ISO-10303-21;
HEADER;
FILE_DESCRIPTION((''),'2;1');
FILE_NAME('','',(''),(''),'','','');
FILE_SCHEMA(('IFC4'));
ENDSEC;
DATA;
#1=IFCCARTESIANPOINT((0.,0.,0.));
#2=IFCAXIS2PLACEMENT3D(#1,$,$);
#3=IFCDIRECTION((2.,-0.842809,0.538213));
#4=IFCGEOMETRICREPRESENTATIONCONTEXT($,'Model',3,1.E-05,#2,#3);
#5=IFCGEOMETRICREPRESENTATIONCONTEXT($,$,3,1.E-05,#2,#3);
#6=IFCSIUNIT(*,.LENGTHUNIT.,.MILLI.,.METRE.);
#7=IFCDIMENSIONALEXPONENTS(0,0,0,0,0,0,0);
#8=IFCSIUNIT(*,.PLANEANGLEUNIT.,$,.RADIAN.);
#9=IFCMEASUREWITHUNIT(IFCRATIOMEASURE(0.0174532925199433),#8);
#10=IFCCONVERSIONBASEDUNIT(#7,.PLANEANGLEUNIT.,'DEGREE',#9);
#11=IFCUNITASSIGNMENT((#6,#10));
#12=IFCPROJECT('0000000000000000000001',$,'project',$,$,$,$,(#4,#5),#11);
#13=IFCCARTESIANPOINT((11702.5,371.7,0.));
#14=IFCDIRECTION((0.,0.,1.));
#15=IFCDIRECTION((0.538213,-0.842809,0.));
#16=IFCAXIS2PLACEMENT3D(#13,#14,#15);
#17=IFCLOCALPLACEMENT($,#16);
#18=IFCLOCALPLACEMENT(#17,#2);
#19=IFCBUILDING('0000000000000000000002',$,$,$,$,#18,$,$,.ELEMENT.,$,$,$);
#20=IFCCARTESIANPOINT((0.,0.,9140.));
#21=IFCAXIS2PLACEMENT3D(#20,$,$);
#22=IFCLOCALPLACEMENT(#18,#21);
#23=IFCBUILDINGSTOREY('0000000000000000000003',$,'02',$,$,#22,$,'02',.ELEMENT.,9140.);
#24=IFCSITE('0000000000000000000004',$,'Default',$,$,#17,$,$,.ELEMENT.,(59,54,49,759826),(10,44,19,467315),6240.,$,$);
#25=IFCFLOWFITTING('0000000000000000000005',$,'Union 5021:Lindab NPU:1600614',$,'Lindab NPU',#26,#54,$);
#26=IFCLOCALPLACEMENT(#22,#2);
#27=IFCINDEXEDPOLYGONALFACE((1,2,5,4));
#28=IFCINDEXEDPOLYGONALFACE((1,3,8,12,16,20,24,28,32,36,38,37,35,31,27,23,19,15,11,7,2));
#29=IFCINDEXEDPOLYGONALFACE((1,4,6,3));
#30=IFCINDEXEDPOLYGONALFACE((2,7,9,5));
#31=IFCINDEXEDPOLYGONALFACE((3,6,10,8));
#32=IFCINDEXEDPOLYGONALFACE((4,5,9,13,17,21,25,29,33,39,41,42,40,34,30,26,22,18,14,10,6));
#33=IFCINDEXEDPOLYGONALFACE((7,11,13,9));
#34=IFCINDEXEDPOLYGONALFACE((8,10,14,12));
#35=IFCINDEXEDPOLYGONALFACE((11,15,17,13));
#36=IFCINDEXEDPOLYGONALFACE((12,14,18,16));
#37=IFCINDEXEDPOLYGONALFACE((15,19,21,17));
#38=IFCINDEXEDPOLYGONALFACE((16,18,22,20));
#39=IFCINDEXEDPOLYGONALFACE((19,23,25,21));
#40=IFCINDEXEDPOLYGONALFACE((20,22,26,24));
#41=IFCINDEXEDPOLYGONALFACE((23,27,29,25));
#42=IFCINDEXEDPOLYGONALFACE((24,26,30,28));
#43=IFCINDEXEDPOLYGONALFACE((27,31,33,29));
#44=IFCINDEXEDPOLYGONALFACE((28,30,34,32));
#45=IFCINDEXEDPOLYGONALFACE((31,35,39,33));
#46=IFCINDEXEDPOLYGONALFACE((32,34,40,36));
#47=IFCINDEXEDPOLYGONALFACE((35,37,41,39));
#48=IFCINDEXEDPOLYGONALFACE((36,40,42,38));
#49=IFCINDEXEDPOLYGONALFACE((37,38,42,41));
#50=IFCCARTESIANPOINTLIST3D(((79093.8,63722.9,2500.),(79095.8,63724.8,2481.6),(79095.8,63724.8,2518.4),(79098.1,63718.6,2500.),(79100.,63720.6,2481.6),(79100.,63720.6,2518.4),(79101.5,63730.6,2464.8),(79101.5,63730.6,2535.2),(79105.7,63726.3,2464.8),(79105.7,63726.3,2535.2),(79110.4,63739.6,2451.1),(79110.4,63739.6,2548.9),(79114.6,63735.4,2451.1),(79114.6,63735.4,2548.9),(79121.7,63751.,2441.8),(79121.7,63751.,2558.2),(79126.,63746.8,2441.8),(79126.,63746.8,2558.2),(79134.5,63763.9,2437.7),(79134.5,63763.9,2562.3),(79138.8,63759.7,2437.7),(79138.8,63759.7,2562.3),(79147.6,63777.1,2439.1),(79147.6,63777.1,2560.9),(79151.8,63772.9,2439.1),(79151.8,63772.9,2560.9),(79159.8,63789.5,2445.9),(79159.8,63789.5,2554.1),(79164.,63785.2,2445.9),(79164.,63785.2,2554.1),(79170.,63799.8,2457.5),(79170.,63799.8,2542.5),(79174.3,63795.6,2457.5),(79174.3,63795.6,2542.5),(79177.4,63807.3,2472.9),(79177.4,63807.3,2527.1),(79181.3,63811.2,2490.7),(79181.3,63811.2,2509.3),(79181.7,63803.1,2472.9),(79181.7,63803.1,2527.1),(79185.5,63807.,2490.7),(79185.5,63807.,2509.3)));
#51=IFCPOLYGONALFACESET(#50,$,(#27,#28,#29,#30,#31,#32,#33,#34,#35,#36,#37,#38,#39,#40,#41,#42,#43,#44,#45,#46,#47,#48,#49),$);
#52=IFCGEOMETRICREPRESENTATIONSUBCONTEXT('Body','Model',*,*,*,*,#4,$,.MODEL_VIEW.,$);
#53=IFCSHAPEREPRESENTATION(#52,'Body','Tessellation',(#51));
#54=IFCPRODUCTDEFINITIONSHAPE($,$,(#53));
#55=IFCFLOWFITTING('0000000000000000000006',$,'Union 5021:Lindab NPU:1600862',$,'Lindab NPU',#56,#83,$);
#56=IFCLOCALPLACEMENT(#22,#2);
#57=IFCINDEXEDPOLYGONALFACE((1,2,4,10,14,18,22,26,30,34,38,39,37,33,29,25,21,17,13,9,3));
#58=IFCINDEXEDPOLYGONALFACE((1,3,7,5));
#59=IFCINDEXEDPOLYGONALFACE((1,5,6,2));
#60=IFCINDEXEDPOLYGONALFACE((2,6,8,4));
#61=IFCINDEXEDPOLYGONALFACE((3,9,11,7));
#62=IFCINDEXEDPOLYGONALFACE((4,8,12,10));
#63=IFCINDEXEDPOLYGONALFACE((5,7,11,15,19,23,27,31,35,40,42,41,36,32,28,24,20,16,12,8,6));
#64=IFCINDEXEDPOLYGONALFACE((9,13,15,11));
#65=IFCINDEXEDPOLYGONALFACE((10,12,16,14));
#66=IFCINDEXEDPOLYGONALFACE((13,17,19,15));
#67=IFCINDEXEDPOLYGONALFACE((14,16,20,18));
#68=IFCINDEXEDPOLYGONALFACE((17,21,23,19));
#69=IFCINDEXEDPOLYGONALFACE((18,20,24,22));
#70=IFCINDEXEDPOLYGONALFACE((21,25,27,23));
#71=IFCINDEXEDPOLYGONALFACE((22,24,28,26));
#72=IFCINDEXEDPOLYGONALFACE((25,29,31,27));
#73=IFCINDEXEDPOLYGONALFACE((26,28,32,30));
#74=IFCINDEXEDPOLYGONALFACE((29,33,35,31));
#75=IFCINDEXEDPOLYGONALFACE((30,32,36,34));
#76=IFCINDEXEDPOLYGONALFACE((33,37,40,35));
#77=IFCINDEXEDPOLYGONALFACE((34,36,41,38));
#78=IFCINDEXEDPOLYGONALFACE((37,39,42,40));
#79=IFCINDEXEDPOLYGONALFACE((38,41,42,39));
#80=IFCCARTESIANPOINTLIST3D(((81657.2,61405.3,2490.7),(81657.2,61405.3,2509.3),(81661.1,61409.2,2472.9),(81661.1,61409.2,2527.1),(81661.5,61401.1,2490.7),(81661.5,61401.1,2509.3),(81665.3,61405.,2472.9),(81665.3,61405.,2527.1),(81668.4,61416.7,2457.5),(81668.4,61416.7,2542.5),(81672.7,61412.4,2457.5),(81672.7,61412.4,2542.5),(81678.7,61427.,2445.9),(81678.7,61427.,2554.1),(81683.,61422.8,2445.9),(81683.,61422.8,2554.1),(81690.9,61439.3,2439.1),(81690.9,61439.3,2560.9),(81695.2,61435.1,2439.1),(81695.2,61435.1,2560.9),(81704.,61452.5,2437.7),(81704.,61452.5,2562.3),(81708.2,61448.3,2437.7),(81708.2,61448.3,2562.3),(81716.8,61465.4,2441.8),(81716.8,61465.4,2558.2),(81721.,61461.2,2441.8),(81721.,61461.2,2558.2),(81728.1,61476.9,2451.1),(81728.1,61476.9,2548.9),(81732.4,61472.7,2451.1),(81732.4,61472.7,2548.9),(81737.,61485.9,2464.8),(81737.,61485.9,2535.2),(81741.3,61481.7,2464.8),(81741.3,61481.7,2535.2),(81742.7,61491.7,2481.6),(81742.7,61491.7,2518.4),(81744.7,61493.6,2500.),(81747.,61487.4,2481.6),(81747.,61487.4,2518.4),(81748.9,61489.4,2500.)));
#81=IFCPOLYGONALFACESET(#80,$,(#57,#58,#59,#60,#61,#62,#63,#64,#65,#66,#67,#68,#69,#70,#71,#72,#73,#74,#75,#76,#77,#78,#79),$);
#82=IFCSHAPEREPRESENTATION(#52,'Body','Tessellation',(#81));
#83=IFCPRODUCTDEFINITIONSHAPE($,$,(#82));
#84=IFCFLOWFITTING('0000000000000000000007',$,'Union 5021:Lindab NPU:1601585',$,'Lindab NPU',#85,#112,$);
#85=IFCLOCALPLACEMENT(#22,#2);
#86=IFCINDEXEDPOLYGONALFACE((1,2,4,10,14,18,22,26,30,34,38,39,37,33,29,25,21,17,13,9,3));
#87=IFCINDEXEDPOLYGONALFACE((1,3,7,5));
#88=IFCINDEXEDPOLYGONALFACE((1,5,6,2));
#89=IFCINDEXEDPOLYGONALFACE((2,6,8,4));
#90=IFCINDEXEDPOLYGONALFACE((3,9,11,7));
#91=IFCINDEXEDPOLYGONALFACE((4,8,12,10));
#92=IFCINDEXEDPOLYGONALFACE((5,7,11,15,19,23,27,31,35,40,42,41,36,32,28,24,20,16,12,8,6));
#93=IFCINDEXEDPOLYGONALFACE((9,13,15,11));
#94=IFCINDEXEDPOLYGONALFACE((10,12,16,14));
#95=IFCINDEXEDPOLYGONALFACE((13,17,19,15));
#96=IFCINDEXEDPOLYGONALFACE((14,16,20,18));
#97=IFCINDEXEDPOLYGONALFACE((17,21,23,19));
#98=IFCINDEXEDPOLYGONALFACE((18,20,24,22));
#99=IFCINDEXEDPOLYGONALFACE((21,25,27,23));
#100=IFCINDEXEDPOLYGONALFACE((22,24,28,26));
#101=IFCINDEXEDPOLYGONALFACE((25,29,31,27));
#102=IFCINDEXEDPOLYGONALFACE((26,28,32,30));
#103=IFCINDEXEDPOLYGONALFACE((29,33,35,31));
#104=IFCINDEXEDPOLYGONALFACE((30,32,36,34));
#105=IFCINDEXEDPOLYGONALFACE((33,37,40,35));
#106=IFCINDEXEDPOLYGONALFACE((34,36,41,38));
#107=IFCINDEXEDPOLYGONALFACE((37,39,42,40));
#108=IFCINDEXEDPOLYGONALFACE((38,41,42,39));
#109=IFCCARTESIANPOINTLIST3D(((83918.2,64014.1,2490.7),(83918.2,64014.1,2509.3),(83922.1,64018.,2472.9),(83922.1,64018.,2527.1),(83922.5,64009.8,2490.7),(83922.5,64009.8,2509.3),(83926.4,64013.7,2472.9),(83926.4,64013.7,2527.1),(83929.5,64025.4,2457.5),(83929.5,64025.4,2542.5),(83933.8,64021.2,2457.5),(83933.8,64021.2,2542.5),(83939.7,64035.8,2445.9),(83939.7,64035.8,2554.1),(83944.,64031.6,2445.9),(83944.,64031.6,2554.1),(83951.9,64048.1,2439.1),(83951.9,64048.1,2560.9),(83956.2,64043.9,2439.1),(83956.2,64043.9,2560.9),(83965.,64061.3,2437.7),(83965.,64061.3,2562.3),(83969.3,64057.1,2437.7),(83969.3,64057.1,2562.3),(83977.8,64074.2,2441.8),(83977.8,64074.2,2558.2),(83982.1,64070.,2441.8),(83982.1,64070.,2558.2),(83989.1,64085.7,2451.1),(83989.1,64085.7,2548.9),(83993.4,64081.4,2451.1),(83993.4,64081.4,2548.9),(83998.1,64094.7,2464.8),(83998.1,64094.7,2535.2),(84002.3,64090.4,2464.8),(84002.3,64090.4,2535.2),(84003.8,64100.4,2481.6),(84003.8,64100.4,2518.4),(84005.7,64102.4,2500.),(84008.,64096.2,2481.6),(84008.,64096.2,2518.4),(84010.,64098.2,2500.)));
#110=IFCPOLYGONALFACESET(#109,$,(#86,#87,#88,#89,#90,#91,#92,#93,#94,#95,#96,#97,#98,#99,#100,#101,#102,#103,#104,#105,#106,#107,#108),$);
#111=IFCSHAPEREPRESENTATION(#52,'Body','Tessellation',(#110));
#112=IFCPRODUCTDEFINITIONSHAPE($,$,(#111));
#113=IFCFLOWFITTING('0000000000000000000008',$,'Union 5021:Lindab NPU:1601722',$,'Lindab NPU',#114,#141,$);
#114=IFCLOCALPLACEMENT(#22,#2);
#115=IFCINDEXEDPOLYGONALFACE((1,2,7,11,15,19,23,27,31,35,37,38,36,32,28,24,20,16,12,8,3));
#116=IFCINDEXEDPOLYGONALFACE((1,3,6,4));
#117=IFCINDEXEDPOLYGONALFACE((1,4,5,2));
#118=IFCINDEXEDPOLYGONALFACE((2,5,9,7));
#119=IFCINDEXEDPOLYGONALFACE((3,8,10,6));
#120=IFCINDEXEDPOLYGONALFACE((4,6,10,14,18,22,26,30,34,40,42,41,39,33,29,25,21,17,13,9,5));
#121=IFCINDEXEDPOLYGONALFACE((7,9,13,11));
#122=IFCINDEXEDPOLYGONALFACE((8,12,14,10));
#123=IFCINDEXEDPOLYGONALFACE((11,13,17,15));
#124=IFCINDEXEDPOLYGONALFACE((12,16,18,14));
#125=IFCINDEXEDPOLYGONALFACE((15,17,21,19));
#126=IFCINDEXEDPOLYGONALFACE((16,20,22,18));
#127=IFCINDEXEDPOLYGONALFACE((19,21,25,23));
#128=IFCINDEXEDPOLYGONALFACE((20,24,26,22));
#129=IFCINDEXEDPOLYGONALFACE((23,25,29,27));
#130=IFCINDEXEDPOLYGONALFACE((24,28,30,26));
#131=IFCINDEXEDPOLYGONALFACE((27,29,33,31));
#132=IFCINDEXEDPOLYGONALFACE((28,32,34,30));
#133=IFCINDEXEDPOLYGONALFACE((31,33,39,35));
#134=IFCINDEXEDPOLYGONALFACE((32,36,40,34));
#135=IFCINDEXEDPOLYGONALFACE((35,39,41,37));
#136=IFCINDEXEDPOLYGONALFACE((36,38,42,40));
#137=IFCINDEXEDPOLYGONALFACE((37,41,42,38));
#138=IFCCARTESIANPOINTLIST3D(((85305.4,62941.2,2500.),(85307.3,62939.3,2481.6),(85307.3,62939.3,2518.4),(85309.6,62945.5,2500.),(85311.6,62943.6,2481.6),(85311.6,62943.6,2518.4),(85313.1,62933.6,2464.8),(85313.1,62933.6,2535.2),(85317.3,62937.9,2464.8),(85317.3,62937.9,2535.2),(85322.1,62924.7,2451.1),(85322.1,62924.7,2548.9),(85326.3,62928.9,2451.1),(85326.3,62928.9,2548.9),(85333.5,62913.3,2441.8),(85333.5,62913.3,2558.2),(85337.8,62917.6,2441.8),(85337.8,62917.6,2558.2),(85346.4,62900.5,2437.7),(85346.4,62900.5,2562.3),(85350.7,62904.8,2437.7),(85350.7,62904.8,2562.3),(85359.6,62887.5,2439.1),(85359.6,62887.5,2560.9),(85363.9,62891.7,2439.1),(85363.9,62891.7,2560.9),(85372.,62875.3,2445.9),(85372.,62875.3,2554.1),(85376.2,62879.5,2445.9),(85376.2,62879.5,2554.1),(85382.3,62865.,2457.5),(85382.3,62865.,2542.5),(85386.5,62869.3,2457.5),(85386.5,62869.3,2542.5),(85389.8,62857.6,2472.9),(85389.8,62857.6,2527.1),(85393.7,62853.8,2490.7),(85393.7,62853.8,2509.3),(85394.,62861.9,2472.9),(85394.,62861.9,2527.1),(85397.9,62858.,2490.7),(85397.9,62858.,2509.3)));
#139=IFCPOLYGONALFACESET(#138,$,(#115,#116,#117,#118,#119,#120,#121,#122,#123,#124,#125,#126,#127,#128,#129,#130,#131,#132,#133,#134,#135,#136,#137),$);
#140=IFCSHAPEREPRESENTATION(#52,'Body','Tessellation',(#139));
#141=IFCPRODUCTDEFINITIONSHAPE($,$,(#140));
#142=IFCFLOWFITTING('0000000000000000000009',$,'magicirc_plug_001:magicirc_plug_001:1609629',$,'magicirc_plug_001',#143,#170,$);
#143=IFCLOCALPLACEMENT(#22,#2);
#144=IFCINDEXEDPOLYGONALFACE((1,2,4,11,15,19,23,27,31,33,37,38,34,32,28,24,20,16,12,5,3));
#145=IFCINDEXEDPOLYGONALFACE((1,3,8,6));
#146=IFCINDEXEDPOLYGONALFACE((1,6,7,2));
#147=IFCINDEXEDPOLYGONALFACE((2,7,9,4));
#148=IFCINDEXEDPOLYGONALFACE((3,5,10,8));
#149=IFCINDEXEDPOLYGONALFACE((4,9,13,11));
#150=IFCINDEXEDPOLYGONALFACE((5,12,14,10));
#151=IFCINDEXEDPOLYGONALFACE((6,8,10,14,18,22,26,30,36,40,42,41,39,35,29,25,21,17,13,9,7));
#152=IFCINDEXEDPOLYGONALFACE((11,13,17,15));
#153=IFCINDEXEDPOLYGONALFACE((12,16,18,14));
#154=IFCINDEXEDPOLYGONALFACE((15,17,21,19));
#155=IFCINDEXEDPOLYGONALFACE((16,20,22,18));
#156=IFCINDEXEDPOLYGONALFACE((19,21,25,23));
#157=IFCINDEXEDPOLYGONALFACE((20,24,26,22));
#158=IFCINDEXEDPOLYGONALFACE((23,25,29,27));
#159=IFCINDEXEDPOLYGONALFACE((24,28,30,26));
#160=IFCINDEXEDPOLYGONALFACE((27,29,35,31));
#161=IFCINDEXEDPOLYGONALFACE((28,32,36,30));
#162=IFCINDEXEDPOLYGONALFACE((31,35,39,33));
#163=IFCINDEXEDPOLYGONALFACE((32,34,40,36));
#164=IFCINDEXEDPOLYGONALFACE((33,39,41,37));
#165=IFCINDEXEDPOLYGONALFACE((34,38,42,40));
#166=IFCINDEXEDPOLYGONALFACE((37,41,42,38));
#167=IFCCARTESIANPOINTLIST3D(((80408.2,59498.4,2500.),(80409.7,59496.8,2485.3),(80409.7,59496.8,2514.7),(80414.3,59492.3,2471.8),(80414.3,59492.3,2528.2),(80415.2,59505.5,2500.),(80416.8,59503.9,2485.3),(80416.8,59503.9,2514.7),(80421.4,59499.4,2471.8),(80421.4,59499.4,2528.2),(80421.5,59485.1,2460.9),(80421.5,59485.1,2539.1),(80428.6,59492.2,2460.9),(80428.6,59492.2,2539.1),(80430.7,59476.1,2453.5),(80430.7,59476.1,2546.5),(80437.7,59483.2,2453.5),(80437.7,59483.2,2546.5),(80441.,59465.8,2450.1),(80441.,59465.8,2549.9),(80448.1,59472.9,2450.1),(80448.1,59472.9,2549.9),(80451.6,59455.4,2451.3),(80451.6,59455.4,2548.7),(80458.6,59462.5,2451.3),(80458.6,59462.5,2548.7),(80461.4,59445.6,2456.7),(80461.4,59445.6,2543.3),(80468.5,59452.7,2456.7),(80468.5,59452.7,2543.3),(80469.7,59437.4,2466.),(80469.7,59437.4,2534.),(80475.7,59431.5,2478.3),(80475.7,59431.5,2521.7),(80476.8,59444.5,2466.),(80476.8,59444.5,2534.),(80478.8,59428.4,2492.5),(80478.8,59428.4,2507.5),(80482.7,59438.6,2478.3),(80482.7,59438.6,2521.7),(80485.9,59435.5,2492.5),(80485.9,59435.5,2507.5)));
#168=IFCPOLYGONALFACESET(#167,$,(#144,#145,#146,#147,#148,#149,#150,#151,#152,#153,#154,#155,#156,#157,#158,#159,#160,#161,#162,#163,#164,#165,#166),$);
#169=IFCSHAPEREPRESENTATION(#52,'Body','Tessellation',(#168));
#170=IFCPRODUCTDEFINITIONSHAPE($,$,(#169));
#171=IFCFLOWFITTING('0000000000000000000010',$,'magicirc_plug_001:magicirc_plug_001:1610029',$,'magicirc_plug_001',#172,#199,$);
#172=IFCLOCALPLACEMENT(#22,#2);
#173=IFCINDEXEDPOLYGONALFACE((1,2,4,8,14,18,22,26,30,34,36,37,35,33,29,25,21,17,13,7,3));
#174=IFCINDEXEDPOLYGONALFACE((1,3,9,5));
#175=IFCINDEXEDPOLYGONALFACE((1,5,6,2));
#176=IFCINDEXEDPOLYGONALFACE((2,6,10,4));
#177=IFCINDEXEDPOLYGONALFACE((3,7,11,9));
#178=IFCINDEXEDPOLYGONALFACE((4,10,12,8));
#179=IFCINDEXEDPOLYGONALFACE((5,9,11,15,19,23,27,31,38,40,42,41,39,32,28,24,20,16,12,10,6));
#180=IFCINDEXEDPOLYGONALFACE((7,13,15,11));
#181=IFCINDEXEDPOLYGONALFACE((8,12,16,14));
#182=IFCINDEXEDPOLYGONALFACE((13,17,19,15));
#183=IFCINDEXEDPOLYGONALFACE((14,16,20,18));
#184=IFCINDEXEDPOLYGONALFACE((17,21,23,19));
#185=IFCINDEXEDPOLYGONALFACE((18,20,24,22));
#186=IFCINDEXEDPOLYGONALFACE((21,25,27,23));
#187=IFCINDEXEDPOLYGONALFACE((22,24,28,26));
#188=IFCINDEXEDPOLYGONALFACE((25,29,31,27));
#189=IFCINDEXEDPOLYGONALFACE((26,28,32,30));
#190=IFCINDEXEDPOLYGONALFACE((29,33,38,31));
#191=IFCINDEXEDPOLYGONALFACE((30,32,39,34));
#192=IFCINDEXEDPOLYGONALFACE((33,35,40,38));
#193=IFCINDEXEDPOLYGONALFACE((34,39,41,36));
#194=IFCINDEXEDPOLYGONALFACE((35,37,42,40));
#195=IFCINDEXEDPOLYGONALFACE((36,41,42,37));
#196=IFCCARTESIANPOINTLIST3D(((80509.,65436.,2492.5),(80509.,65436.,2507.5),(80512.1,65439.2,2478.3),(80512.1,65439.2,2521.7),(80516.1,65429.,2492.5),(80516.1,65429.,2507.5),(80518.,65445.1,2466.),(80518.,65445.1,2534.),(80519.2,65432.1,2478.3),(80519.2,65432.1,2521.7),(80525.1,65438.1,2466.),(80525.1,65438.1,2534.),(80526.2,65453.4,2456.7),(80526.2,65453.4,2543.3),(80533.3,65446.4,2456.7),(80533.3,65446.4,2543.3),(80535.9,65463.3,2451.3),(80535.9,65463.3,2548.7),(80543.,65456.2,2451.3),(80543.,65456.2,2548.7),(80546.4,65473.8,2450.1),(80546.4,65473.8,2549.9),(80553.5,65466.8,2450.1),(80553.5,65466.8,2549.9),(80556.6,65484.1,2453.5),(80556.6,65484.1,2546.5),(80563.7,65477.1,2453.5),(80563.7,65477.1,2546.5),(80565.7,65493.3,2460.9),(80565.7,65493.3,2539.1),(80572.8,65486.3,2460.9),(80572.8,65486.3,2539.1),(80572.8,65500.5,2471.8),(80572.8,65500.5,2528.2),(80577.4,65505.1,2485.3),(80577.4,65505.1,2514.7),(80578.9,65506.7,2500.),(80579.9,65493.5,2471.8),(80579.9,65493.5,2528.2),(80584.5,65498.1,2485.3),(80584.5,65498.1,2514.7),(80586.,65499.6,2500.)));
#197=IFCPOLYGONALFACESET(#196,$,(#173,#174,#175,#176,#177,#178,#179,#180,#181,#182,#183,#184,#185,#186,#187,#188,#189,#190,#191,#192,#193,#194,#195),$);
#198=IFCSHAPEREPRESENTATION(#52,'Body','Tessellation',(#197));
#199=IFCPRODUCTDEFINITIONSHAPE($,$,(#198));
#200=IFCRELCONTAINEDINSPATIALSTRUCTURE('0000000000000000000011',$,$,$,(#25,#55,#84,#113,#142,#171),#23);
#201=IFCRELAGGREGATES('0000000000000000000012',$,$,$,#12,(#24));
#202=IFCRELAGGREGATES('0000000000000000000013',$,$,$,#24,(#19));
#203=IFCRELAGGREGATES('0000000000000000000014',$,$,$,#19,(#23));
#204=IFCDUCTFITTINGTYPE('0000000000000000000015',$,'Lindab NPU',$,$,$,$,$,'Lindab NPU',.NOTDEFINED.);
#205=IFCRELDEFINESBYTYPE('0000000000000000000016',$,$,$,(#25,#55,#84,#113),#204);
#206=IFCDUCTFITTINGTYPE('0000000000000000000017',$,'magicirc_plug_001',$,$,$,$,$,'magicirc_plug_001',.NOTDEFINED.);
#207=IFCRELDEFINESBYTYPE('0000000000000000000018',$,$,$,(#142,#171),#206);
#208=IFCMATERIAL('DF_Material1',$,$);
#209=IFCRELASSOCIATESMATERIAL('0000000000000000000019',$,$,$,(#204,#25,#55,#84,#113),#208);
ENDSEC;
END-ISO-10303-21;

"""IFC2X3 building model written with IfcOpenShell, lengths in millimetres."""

from ifc_helpers import new_model, entity, si_unit, converted_unit, direction, frame, frame_2d, origin, place, context, subcontext, project, spatial, circle, extrude, source, transform, mapped, material, type_object, type_shapes, element, save


model = new_model("IFC2X3")

# Units and contexts
model_context = context("Model", 3, precision=1e-05, world=origin(), true_north=direction((2.0, -0.842809, 0.538213)))
context_of_model = context(None, 3, precision=1e-05, world=origin(), true_north=direction((2.0, -0.842809, 0.538213)))
body_context = subcontext(model_context, "Body", "Model", "MODEL_VIEW")
ifc_project = project(units=[si_unit("LENGTHUNIT", "METRE", prefix="MILLI"), converted_unit("PLANEANGLEUNIT", "DEGREE", entity("IfcRatioMeasure", 0.0174532925199433), si_unit("PLANEANGLEUNIT", "RADIAN"), dimensions=[0, 0, 0, 0, 0, 0, 0])], contexts=[model_context, context_of_model])

# Site, building, storey
site_placement = place(None, frame((11702.5, 371.7, 0.0), z_axis=(0.0, 0.0, 1.0), x_axis=(0.538213, -0.842809, 0.0)))
site = spatial("IfcSite", under=ifc_project, at=site_placement, Name="Default", CompositionType="ELEMENT", RefLatitude=(59, 54, 49, 759826), RefLongitude=(10, 44, 19, 467315), RefElevation=6240.0)
building_placement = place(site_placement, origin())
building = spatial("IfcBuilding", under=site, at=building_placement, CompositionType="ELEMENT")
storey_placement = place(building_placement, frame((0.0, 0.0, 9140.0)))
storey = spatial("IfcBuildingStorey", under=building, at=storey_placement, Name="02", LongName="02", CompositionType="ELEMENT", Elevation=9140.0)

# Flow fittings
ifc_material = material(Name="DF_Material1")
duct_fitting_type_1 = type_object("IfcDuctFittingType", Name="Lindab NPU", ElementType="Lindab NPU", PredefinedType="NOTDEFINED", material=ifc_material)
shared_shape_1 = source(origin(), body_context, "Body", "SweptSolid", [
    extrude(circle(Radius=62.5, at=frame_2d((0.0, 0.0), x_axis=(1.0, 0.0))), frame((0.0, 0.0, 0.0), z_axis=(1.0, 0.0, 0.0), x_axis=(0.0, 1.0, 0.0)), (0.0, 0.0, 1.0), 6.0),
])
type_shapes(duct_fitting_type_1, [shared_shape_1])
for number, where, z_axis, x_axis, name in (
    (1, (79142.1, 63763.0, 2500.0), (0.0, 0.0, 1.0), (-0.710528, 0.703669, 0.0), "Union 5021:Lindab NPU:1600614"),
    (2, (81700.7, 61449.2, 2500.0), (0.0, 0.0, 1.0), (0.710528, -0.703669, 0.0), "Union 5021:Lindab NPU:1600862"),
    (3, (83961.7, 64058.0, 2500.0), (0.0, 0.0, 1.0), (0.710528, -0.703669, 0.0), "Union 5021:Lindab NPU:1601585"),
    (4, (85349.8, 62897.3, 2500.0), (0.0, 0.0, 1.0), (0.703669, 0.710528, 0.0), "Union 5021:Lindab NPU:1601722"),
):
    element("IfcFlowFitting", number, at=place(storey_placement, frame(where, z_axis=z_axis, x_axis=x_axis)), inside=storey, type_object=duct_fitting_type_1, material=ifc_material, Name=name, ObjectType="Lindab NPU", context=body_context, shape_type="MappedRepresentation", body=[
        mapped(shared_shape_1, transform((0.0, 0.0, 0.0), scale=1.0)),
    ])
duct_fitting_type_2 = type_object("IfcDuctFittingType", Name="magicirc_plug_001", ElementType="magicirc_plug_001", PredefinedType="NOTDEFINED")
shared_shape_2 = source(origin(), body_context, "Body", "SweptSolid", [
    extrude(circle(Radius=50.0, at=frame_2d((0.0, 0.0), x_axis=(1.0, 0.0))), frame((0.0, 0.0, 0.0), z_axis=(1.0, 0.0, 0.0), x_axis=(0.0, 1.0, 0.0)), (0.0, 0.0, 1.0), 10.0),
])
type_shapes(duct_fitting_type_2, [shared_shape_2])
for number, where, z_axis, x_axis, name in (
    (5, (80443.7, 59463.2, 2500.0), (0.0, 0.0, 1.0), (0.703669, 0.710528, 0.0), "magicirc_plug_001:magicirc_plug_001:1609629"),
    (6, (80543.8, 65471.2, 2500.0), (0.0, 0.0, 1.0), (0.710528, -0.703669, 0.0), "magicirc_plug_001:magicirc_plug_001:1610029"),
):
    element("IfcFlowFitting", number, at=place(storey_placement, frame(where, z_axis=z_axis, x_axis=x_axis)), inside=storey, type_object=duct_fitting_type_2, Name=name, ObjectType="magicirc_plug_001", context=body_context, shape_type="MappedRepresentation", body=[
        mapped(shared_shape_2, transform((0.0, 0.0, 0.0), scale=1.0)),
    ])

save(model, "model.ifc")
